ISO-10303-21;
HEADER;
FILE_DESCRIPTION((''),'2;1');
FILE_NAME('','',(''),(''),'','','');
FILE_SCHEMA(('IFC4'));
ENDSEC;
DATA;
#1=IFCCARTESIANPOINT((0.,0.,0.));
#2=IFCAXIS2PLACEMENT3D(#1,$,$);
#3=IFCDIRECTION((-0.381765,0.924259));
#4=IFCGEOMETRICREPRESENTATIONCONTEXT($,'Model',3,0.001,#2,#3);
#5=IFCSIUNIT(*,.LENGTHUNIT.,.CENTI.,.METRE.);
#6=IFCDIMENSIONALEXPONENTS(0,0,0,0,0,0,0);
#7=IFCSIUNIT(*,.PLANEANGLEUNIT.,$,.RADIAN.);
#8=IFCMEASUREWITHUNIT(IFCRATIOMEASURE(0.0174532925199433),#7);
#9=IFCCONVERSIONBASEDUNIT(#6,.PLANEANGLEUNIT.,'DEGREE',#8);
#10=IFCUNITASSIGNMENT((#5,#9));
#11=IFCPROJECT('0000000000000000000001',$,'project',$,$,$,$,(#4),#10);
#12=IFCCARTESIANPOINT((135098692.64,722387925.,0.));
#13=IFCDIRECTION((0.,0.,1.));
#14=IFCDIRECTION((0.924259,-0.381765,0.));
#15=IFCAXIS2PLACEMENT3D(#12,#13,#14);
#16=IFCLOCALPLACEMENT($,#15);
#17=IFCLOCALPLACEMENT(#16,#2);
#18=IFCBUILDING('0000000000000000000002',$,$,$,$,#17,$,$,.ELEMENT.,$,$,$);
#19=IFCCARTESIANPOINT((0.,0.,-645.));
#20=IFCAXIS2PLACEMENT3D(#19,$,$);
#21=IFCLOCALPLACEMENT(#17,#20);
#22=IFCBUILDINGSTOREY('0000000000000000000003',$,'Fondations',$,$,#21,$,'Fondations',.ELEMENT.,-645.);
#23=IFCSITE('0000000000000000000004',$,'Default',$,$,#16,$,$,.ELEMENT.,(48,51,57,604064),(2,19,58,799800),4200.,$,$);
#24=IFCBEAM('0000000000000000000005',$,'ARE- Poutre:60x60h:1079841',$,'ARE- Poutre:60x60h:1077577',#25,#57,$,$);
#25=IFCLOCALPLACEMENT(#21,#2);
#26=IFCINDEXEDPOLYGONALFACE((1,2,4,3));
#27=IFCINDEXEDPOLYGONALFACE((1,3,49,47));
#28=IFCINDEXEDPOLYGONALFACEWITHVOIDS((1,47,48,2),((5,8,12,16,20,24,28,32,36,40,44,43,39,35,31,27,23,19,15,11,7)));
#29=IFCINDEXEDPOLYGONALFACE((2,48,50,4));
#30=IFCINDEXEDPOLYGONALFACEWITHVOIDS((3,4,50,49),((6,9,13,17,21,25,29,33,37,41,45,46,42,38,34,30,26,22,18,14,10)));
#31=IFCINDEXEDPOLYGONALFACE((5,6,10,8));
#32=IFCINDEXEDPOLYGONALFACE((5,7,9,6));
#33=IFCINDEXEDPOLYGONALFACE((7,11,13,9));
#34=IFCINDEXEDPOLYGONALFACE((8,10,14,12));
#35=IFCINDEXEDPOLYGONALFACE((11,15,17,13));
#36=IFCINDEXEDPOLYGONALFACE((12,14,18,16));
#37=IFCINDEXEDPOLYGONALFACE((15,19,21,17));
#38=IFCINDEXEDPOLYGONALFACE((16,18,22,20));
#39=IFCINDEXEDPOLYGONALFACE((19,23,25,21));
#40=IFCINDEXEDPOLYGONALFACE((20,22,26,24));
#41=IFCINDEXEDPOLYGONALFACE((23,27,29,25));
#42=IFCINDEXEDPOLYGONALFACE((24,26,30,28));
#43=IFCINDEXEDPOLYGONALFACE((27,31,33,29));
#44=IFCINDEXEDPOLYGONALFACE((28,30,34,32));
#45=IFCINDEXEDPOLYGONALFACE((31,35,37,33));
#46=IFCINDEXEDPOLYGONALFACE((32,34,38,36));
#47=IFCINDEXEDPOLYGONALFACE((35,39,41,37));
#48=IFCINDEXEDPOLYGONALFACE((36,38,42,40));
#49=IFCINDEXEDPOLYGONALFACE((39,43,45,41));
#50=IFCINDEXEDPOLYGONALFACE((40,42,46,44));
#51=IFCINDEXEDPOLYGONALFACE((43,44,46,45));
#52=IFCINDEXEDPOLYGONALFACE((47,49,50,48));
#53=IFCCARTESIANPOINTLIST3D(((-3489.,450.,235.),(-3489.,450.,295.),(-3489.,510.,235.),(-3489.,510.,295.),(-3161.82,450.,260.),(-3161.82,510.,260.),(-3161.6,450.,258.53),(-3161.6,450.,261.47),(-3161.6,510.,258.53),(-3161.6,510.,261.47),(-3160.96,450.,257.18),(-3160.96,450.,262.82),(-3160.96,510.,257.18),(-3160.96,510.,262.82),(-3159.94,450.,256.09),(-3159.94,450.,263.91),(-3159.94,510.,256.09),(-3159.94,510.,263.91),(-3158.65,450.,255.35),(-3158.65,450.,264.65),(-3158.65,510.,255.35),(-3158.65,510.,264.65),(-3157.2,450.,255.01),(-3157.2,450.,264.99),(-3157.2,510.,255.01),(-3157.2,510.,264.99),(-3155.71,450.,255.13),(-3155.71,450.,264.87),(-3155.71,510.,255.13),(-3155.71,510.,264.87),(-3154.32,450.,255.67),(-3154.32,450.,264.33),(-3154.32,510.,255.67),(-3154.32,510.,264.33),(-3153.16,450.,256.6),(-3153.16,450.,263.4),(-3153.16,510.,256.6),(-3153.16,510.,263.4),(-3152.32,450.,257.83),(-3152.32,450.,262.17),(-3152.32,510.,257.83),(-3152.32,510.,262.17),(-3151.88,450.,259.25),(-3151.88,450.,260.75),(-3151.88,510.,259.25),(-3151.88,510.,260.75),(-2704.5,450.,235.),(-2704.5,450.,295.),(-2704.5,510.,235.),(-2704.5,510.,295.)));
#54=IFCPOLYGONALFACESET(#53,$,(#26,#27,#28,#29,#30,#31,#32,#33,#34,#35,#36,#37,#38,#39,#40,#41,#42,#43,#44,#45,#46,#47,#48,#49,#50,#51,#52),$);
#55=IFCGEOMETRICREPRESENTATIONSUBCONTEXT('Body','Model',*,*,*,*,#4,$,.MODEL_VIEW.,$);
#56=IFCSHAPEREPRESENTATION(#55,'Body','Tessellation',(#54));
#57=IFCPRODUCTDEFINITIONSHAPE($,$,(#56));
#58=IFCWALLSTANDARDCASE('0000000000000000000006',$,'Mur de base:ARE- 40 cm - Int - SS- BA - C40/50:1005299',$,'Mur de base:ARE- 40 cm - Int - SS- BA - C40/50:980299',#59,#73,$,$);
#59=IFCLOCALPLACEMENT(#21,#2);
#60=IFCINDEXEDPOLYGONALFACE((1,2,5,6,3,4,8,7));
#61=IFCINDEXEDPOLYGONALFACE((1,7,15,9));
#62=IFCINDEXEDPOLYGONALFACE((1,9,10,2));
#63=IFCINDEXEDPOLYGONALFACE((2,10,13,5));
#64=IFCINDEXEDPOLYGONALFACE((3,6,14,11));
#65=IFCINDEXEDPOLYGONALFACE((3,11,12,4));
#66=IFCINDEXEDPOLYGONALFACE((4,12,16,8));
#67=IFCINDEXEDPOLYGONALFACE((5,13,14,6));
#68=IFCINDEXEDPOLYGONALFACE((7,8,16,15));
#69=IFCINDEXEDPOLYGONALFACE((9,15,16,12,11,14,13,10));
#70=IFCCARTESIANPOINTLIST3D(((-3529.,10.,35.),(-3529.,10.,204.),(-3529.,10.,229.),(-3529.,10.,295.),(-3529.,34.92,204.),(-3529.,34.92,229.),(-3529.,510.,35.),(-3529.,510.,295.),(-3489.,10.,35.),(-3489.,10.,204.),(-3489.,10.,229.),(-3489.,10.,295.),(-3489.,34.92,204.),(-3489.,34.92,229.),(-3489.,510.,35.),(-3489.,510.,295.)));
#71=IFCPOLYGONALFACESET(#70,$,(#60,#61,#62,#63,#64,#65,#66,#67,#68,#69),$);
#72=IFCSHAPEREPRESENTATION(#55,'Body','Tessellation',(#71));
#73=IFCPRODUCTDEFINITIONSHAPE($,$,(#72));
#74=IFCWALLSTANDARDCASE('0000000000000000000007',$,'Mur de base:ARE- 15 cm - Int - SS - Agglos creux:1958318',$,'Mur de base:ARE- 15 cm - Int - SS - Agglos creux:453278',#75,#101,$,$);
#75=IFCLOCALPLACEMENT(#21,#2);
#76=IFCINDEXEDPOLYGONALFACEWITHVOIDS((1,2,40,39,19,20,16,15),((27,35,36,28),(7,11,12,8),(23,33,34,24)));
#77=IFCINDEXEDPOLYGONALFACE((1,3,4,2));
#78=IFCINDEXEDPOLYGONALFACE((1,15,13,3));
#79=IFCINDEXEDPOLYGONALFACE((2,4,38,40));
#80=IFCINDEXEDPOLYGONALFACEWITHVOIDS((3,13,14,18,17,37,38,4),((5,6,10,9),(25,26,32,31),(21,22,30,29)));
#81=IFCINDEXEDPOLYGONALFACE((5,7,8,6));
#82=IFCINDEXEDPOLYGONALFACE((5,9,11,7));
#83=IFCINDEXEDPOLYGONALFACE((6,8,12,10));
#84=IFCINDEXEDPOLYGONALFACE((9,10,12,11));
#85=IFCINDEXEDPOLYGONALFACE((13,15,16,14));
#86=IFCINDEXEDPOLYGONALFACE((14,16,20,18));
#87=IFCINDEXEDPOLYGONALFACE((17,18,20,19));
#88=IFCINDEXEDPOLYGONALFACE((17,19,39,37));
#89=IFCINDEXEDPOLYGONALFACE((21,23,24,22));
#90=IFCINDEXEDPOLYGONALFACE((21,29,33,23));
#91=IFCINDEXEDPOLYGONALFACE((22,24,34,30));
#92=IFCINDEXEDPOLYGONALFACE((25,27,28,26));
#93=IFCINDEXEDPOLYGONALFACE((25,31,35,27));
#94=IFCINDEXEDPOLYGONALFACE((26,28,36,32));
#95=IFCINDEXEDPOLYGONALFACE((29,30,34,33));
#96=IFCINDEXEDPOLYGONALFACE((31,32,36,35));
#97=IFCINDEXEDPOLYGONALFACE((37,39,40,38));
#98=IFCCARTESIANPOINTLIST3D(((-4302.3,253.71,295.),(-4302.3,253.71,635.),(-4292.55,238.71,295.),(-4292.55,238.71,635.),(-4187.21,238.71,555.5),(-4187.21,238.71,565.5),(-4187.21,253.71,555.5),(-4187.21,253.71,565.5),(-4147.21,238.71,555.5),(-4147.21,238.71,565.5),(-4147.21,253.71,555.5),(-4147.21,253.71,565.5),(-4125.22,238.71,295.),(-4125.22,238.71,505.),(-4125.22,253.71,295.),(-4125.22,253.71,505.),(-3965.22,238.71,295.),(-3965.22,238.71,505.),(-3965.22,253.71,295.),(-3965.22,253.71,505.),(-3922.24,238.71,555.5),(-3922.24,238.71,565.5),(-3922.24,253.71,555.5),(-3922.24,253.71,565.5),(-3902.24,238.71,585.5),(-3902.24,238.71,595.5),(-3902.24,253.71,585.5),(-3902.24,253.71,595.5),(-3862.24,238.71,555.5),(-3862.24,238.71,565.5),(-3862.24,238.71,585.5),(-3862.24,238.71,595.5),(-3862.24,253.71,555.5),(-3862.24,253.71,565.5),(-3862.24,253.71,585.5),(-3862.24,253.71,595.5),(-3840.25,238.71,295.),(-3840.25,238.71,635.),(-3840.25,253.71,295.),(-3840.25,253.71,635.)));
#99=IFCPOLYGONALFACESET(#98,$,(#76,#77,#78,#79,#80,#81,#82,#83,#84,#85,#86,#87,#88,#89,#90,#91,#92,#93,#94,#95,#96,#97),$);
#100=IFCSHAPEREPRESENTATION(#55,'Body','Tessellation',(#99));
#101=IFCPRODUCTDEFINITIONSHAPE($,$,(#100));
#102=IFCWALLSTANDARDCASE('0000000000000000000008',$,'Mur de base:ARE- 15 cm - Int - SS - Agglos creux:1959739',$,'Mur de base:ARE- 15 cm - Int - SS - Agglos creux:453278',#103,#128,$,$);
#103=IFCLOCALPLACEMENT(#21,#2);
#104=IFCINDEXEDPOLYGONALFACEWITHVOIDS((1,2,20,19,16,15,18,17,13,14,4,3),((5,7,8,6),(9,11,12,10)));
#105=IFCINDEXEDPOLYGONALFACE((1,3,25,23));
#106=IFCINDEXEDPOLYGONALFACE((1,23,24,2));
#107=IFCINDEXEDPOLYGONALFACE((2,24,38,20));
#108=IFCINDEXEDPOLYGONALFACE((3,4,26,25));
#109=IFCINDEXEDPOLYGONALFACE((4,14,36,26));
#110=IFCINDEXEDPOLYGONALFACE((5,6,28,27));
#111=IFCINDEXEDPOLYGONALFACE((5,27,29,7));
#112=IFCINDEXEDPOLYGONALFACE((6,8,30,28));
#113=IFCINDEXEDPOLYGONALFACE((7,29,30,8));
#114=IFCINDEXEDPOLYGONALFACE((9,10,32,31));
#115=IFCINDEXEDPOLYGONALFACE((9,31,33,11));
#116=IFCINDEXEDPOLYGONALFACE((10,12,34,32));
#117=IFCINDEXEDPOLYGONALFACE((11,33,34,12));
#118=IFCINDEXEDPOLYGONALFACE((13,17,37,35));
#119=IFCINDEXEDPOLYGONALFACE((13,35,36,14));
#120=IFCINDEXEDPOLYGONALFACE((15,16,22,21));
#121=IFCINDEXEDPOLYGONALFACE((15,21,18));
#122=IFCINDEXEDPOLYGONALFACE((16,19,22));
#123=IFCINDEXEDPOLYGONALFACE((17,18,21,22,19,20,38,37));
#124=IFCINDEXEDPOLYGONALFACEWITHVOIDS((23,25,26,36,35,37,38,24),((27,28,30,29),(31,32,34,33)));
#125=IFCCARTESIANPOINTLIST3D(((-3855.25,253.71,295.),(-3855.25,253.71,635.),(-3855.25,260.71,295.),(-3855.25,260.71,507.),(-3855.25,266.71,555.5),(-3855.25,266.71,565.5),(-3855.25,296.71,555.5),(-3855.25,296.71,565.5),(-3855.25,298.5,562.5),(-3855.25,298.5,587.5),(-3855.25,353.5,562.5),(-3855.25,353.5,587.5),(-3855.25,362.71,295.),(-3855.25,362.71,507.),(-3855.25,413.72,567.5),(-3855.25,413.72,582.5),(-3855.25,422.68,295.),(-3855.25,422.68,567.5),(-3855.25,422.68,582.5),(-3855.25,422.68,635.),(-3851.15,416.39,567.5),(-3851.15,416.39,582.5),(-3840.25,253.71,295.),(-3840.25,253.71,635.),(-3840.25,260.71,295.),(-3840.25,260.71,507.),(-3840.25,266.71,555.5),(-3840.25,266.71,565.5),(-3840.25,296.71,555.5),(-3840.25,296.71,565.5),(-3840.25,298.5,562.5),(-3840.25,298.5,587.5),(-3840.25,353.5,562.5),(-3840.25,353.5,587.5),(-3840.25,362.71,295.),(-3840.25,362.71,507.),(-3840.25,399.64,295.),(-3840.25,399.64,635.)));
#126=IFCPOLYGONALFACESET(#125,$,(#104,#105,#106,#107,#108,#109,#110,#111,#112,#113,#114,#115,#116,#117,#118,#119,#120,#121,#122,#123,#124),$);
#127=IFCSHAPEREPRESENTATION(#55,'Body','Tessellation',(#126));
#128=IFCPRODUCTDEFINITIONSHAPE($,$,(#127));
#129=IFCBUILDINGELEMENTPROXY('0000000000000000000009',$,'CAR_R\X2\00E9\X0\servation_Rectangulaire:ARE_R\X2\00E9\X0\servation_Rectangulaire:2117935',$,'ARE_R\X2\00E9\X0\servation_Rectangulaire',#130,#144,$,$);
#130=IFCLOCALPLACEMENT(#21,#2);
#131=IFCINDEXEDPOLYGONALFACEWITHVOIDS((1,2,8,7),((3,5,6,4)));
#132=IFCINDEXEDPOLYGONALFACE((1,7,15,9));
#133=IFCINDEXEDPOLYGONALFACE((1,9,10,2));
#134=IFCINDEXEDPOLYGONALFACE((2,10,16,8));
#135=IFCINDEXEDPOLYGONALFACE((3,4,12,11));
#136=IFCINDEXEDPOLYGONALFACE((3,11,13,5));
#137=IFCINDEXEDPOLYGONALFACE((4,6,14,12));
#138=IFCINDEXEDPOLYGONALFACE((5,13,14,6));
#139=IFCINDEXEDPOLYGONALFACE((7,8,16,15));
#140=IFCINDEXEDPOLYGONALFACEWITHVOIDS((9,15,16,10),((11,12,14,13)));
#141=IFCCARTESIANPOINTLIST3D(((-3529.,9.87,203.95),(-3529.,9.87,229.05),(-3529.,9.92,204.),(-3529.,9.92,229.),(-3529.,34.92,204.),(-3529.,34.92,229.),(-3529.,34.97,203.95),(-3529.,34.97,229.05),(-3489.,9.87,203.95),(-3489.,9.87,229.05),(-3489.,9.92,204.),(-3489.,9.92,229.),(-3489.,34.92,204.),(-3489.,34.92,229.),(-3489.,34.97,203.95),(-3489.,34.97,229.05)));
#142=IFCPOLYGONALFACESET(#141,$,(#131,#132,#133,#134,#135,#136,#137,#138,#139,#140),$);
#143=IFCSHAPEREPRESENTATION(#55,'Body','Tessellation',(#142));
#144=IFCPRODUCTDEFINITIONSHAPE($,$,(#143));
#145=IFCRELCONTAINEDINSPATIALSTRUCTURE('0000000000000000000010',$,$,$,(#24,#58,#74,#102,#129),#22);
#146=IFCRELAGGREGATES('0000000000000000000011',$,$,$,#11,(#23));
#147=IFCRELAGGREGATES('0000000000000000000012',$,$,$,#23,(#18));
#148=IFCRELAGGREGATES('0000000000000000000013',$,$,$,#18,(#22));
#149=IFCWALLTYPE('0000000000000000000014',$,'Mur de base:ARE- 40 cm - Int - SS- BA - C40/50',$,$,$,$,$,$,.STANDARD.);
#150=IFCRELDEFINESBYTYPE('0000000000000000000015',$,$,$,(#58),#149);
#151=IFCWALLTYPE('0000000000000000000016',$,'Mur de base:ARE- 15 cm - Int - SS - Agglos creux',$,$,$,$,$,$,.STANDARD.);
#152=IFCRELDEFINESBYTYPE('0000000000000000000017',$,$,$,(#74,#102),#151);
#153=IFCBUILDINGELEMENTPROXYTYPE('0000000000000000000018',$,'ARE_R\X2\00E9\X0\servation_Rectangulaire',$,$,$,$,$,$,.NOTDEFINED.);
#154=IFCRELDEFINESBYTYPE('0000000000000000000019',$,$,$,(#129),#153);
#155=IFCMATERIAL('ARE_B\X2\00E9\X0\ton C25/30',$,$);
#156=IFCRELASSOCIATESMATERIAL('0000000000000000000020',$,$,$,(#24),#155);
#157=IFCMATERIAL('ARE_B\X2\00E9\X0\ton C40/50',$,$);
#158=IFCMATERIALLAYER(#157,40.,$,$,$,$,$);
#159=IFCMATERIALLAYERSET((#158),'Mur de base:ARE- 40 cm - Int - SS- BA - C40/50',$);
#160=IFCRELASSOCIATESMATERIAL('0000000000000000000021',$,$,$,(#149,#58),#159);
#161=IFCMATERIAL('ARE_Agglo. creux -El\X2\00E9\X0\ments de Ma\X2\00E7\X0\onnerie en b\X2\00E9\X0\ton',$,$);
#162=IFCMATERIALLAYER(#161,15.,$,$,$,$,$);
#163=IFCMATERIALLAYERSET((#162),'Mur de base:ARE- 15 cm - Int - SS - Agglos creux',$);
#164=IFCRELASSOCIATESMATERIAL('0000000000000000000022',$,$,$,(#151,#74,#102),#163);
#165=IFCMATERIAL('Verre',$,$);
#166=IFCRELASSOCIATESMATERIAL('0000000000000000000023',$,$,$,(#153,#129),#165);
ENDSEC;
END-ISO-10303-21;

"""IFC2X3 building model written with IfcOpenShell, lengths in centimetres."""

from ifc_helpers import new_model, entity, si_unit, converted_unit, direction, frame, frame_2d, origin, origin_2d_with_axis, place, context, subcontext, project, spatial, polyline, rectangle, circle, outline, extrude, boolean, source, transform, mapped, material, layer, layer_set, layer_usage, type_object, type_shapes, element, save


model = new_model("IFC2X3")

# Units and contexts
model_context = context("Model", 3, precision=0.001, world=origin(), true_north=direction((-0.381765, 0.924259)))
body_context = subcontext(model_context, "Body", "Model", "MODEL_VIEW")
ifc_project = project(units=[si_unit("LENGTHUNIT", "METRE", prefix="CENTI"), converted_unit("PLANEANGLEUNIT", "DEGREE", entity("IfcRatioMeasure", 0.0174532925199433), si_unit("PLANEANGLEUNIT", "RADIAN"), dimensions=[0, 0, 0, 0, 0, 0, 0])], contexts=[model_context])

# Site, building, storey
site_placement = place(None, frame((135098692.64, 722387925.0, 0.0), z_axis=(0.0, 0.0, 1.0), x_axis=(0.924259, -0.381765, 0.0)))
site = spatial("IfcSite", under=ifc_project, at=site_placement, Name="Default", CompositionType="ELEMENT", RefLatitude=(48, 51, 57, 604064), RefLongitude=(2, 19, 58, 799800), RefElevation=4200.0)
building_placement = place(site_placement, origin())
building = spatial("IfcBuilding", under=site, at=building_placement, CompositionType="ELEMENT")
storey_placement = place(building_placement, frame((0.0, 0.0, -645.0)))
storey = spatial("IfcBuildingStorey", under=building, at=storey_placement, Name="Fondations", LongName="Fondations", CompositionType="ELEMENT", Elevation=-645.0)

# Beam
ifc_material_1 = material(Name="ARE_Béton C25/30")
beam_placement = place(storey_placement, frame((-3509.0, 480.0, 295.0)))
element("IfcBeam", 1, at=beam_placement, inside=storey, material=ifc_material_1, Name="ARE- Poutre:60x60h:1079841", ObjectType="ARE- Poutre:60x60h:1077577", context=body_context, shape_type="CSG", body=[
    boolean("DIFFERENCE", extrude(rectangle(XDim=60.0, YDim=60.0, at=frame_2d((0.0, 0.0), x_axis=(0.0, 1.0))), frame((20.0, 0.0, -30.0), z_axis=(1.0, 0.0, 0.0), x_axis=(0.0, 1.0, 0.0)), (0.0, 0.0, 1.0), 784.5), extrude(circle(Radius=5.0, at=frame_2d((0.0, 0.0), x_axis=(1.0, 0.0))), frame((352.18, -30.0, -35.0), z_axis=(0.0, 1.0, 0.0), x_axis=(-1.0, 0.0, 0.0)), (0.0, 0.0, 1.0), 60.0)),
])

# Wall, opening
ifc_material_2 = material(Name="ARE_Béton C40/50")
ifc_layer_1 = layer(ifc_material_2, 40.0)
ifc_layer_set_1 = layer_set([ifc_layer_1], Name="Mur de base:ARE- 40 cm - Int - SS- BA - C40/50")
ifc_layer_usage_1 = layer_usage(ifc_layer_set_1, "AXIS2", "NEGATIVE", 20.0)
wall_type_1 = type_object("IfcWallType", Name="Mur de base:ARE- 40 cm - Int - SS- BA - C40/50", PredefinedType="STANDARD", material=ifc_layer_set_1)
wall_1_placement = place(storey_placement, frame((-3509.0, 510.0, 35.0), z_axis=(0.0, 0.0, 1.0), x_axis=(0.0, -1.0, 0.0)))
wall_1 = element("IfcWallStandardCase", 2, at=wall_1_placement, inside=storey, type_object=wall_type_1, material=ifc_layer_usage_1, Name="Mur de base:ARE- 40 cm - Int - SS- BA - C40/50:1005299", ObjectType="Mur de base:ARE- 40 cm - Int - SS- BA - C40/50:980299", context=body_context, shape_type="SweptSolid", body=[
    extrude(rectangle(XDim=500.0, YDim=40.0, at=frame_2d((250.0, 0.0), x_axis=(-1.0, 0.0))), origin(), (0.0, 0.0, 1.0), 260.0),
])
opening_1_placement = place(wall_1_placement, origin())
element("IfcOpeningElement", 3, at=opening_1_placement, cuts=wall_1, ObjectType="Opening", context=body_context, shape_type="SweptSolid", body=[
    extrude(rectangle(XDim=25.0, YDim=25.0, at=frame_2d((0.0, 0.0), x_axis=(0.0, 1.0))), frame((487.58, -20.0, 181.5), z_axis=(0.0, 1.0, 0.0), x_axis=(1.0, 0.0, 0.0)), (0.0, 0.0, 1.0), 40.0),
])

# Walls, openings
ifc_material_3 = material(Name="ARE_Agglo. creux -Eléments de Maçonnerie en béton")
ifc_layer_2 = layer(ifc_material_3, 15.0)
ifc_layer_set_2 = layer_set([ifc_layer_2], Name="Mur de base:ARE- 15 cm - Int - SS - Agglos creux")
ifc_layer_usage_2 = layer_usage(ifc_layer_set_2, "AXIS2", "NEGATIVE", 7.5)
wall_type_2 = type_object("IfcWallType", Name="Mur de base:ARE- 15 cm - Int - SS - Agglos creux", PredefinedType="STANDARD", material=ifc_layer_set_2)
wall_2_placement = place(storey_placement, frame((-3840.25, 246.21, 295.0), z_axis=(0.0, 0.0, 1.0), x_axis=(-1.0, 0.0, 0.0)))
wall_2 = element("IfcWallStandardCase", 4, at=wall_2_placement, inside=storey, type_object=wall_type_2, material=ifc_layer_usage_2, Name="Mur de base:ARE- 15 cm - Int - SS - Agglos creux:1958318", ObjectType="Mur de base:ARE- 15 cm - Int - SS - Agglos creux:453278", context=body_context, shape_type="SweptSolid", body=[
    extrude(outline(polyline([(0.0, -7.5), (15.0, -7.5), (286.97, -7.5), (301.97, -7.5), (444.16, -7.5), (462.05, -7.5), (452.3, 7.5), (0.0, 7.5), (0.0, -7.5)])), origin(), (0.0, 0.0, 1.0), 340.0),
])
opening_2_placement = place(wall_2_placement, origin())
element("IfcOpeningElement", 5, at=opening_2_placement, cuts=wall_2, ObjectType="Opening", context=body_context, shape_type="SweptSolid", body=[
    extrude(rectangle(XDim=10.0, YDim=40.0, at=frame_2d((0.0, 0.0), x_axis=(0.0, 1.0))), frame((326.96, -7.5, 265.5), z_axis=(0.0, 1.0, 0.0), x_axis=(1.0, 0.0, 0.0)), (0.0, 0.0, 1.0), 15.0),
])
opening_3_placement = place(wall_2_placement, origin())
element("IfcOpeningElement", 6, at=opening_3_placement, cuts=wall_2, ObjectType="Opening", context=body_context, shape_type="SweptSolid", body=[
    extrude(rectangle(XDim=10.0, YDim=40.0, at=frame_2d((0.0, 0.0), x_axis=(0.0, 1.0))), frame((41.99, -7.5, 295.5), z_axis=(0.0, 1.0, 0.0), x_axis=(1.0, 0.0, 0.0)), (0.0, 0.0, 1.0), 15.0),
])
opening_4_placement = place(wall_2_placement, origin())
element("IfcOpeningElement", 7, at=opening_4_placement, cuts=wall_2, ObjectType="Opening", context=body_context, shape_type="SweptSolid", body=[
    extrude(rectangle(XDim=10.0, YDim=60.0, at=frame_2d((0.0, 0.0), x_axis=(0.0, 1.0))), frame((51.99, -7.5, 265.5), z_axis=(0.0, 1.0, 0.0), x_axis=(1.0, 0.0, 0.0)), (0.0, 0.0, 1.0), 15.0),
])
opening_5_placement = place(wall_2_placement, frame((-3840.25, 246.21, -295.0), z_axis=(0.0, 0.0, 1.0), x_axis=(-1.0, 0.0, 0.0)))
element("IfcOpeningElement", 8, at=opening_5_placement, cuts=wall_2, ObjectType="Opening", context=body_context, shape_type="SweptSolid", body=[
    extrude(rectangle(XDim=210.0, YDim=160.0, at=frame_2d((0.0, 0.0), x_axis=(0.0, 1.0))), frame((-4045.22, 406.11, 400.0), z_axis=(0.0, -1.0, 0.0), x_axis=(-1.0, 0.0, 0.0)), (0.0, 0.0, 1.0), 304.8),
])
ifc_layer_usage_3 = layer_usage(ifc_layer_set_2, "AXIS2", "NEGATIVE", 7.5)
wall_3_placement = place(storey_placement, frame((-3847.75, 253.71, 295.0), z_axis=(0.0, 0.0, 1.0), x_axis=(0.0, 1.0, 0.0)))
wall_3 = element("IfcWallStandardCase", 9, at=wall_3_placement, inside=storey, type_object=wall_type_2, material=ifc_layer_usage_3, Name="Mur de base:ARE- 15 cm - Int - SS - Agglos creux:1959739", ObjectType="Mur de base:ARE- 15 cm - Int - SS - Agglos creux:453278", context=body_context, shape_type="SweptSolid", body=[
    extrude(outline(polyline([(0.0, -7.5), (145.93, -7.5), (168.97, 7.5), (141.48, 7.5), (0.0, 7.5), (0.0, -7.5)])), origin(), (0.0, 0.0, 1.0), 340.0),
])
opening_6_placement = place(wall_3_placement, origin())
element("IfcOpeningElement", 10, at=opening_6_placement, cuts=wall_3, ObjectType="Opening", context=body_context, shape_type="SweptSolid", body=[
    extrude(rectangle(XDim=15.0, YDim=30.0, at=frame_2d((0.0, 0.0), x_axis=(1.0, 0.0))), frame((175.25, 11.59, 280.0), z_axis=(-0.545548, 0.83808, 0.0), x_axis=(0.0, 0.0, -1.0)), (0.0, 0.0, 1.0), 15.0),
])
opening_7_placement = place(wall_3_placement, origin())
element("IfcOpeningElement", 11, at=opening_7_placement, cuts=wall_3, ObjectType="Opening", context=body_context, shape_type="SweptSolid", body=[
    extrude(rectangle(XDim=25.0, YDim=55.0, at=frame_2d((0.0, 0.0), x_axis=(1.0, 0.0))), frame((72.29, -7.5, 280.0), z_axis=(0.0, 1.0, 0.0), x_axis=(0.0, 0.0, -1.0)), (0.0, 0.0, 1.0), 15.0),
])
opening_8_placement = place(wall_3_placement, origin())
element("IfcOpeningElement", 12, at=opening_8_placement, cuts=wall_3, ObjectType="Opening", context=body_context, shape_type="SweptSolid", body=[
    extrude(rectangle(XDim=10.0, YDim=30.0, at=frame_2d((0.0, 0.0), x_axis=(0.0, 1.0))), frame((28.0, -7.5, 265.5), z_axis=(0.0, 1.0, 0.0), x_axis=(1.0, 0.0, 0.0)), (0.0, 0.0, 1.0), 15.0),
])
opening_9_placement = place(wall_3_placement, frame((-253.71, -3847.75, -295.0), z_axis=(0.0, 0.0, 1.0), x_axis=(0.0, -1.0, 0.0)))
element("IfcOpeningElement", 13, at=opening_9_placement, cuts=wall_3, ObjectType="Opening", context=body_context, shape_type="SweptSolid", body=[
    extrude(rectangle(XDim=212.0, YDim=102.0, at=origin_2d_with_axis()), frame((-3702.85, 311.71, 401.0), z_axis=(-1.0, 0.0, 0.0), x_axis=(0.0, 0.0, -1.0)), (0.0, 0.0, 1.0), 304.8),
])

# Building element proxy
ifc_material_4 = material(Name="Verre")
building_element_proxy_type_1 = type_object("IfcBuildingElementProxyType", Name="ARE_Réservation_Rectangulaire", PredefinedType="NOTDEFINED", material=ifc_material_4)
shared_shape_1 = source(origin(), body_context, "Body", "SweptSolid", [
    extrude(outline(polyline([(-12.55, -12.55), (12.55, -12.55), (12.55, 12.55), (-12.55, 12.55), (-12.55, -12.55)]), holes=[polyline([(12.5, -12.5), (-12.5, -12.5), (-12.5, 12.5), (12.5, 12.5), (12.5, -12.5)])]), frame((0.0, 0.0, -40.0), z_axis=(0.0, 0.0, 1.0), x_axis=(-1.0, 0.0, 0.0)), (0.0, 0.0, 1.0), 40.0),
])
type_shapes(building_element_proxy_type_1, [shared_shape_1])
proxy_1_placement = place(storey_placement, frame((-3489.0, 22.42, 216.5), z_axis=(1.0, 0.0, 0.0), x_axis=(0.0, 1.0, 0.0)))
element("IfcBuildingElementProxy", 14, at=proxy_1_placement, inside=storey, type_object=building_element_proxy_type_1, material=ifc_material_4, Name="CAR_Réservation_Rectangulaire:ARE_Réservation_Rectangulaire:2117935", ObjectType="ARE_Réservation_Rectangulaire", context=body_context, shape_type="MappedRepresentation", body=[
    mapped(shared_shape_1, transform((0.0, 0.0, 0.0), scale=1.0)),
])

save(model, "model.ifc")
